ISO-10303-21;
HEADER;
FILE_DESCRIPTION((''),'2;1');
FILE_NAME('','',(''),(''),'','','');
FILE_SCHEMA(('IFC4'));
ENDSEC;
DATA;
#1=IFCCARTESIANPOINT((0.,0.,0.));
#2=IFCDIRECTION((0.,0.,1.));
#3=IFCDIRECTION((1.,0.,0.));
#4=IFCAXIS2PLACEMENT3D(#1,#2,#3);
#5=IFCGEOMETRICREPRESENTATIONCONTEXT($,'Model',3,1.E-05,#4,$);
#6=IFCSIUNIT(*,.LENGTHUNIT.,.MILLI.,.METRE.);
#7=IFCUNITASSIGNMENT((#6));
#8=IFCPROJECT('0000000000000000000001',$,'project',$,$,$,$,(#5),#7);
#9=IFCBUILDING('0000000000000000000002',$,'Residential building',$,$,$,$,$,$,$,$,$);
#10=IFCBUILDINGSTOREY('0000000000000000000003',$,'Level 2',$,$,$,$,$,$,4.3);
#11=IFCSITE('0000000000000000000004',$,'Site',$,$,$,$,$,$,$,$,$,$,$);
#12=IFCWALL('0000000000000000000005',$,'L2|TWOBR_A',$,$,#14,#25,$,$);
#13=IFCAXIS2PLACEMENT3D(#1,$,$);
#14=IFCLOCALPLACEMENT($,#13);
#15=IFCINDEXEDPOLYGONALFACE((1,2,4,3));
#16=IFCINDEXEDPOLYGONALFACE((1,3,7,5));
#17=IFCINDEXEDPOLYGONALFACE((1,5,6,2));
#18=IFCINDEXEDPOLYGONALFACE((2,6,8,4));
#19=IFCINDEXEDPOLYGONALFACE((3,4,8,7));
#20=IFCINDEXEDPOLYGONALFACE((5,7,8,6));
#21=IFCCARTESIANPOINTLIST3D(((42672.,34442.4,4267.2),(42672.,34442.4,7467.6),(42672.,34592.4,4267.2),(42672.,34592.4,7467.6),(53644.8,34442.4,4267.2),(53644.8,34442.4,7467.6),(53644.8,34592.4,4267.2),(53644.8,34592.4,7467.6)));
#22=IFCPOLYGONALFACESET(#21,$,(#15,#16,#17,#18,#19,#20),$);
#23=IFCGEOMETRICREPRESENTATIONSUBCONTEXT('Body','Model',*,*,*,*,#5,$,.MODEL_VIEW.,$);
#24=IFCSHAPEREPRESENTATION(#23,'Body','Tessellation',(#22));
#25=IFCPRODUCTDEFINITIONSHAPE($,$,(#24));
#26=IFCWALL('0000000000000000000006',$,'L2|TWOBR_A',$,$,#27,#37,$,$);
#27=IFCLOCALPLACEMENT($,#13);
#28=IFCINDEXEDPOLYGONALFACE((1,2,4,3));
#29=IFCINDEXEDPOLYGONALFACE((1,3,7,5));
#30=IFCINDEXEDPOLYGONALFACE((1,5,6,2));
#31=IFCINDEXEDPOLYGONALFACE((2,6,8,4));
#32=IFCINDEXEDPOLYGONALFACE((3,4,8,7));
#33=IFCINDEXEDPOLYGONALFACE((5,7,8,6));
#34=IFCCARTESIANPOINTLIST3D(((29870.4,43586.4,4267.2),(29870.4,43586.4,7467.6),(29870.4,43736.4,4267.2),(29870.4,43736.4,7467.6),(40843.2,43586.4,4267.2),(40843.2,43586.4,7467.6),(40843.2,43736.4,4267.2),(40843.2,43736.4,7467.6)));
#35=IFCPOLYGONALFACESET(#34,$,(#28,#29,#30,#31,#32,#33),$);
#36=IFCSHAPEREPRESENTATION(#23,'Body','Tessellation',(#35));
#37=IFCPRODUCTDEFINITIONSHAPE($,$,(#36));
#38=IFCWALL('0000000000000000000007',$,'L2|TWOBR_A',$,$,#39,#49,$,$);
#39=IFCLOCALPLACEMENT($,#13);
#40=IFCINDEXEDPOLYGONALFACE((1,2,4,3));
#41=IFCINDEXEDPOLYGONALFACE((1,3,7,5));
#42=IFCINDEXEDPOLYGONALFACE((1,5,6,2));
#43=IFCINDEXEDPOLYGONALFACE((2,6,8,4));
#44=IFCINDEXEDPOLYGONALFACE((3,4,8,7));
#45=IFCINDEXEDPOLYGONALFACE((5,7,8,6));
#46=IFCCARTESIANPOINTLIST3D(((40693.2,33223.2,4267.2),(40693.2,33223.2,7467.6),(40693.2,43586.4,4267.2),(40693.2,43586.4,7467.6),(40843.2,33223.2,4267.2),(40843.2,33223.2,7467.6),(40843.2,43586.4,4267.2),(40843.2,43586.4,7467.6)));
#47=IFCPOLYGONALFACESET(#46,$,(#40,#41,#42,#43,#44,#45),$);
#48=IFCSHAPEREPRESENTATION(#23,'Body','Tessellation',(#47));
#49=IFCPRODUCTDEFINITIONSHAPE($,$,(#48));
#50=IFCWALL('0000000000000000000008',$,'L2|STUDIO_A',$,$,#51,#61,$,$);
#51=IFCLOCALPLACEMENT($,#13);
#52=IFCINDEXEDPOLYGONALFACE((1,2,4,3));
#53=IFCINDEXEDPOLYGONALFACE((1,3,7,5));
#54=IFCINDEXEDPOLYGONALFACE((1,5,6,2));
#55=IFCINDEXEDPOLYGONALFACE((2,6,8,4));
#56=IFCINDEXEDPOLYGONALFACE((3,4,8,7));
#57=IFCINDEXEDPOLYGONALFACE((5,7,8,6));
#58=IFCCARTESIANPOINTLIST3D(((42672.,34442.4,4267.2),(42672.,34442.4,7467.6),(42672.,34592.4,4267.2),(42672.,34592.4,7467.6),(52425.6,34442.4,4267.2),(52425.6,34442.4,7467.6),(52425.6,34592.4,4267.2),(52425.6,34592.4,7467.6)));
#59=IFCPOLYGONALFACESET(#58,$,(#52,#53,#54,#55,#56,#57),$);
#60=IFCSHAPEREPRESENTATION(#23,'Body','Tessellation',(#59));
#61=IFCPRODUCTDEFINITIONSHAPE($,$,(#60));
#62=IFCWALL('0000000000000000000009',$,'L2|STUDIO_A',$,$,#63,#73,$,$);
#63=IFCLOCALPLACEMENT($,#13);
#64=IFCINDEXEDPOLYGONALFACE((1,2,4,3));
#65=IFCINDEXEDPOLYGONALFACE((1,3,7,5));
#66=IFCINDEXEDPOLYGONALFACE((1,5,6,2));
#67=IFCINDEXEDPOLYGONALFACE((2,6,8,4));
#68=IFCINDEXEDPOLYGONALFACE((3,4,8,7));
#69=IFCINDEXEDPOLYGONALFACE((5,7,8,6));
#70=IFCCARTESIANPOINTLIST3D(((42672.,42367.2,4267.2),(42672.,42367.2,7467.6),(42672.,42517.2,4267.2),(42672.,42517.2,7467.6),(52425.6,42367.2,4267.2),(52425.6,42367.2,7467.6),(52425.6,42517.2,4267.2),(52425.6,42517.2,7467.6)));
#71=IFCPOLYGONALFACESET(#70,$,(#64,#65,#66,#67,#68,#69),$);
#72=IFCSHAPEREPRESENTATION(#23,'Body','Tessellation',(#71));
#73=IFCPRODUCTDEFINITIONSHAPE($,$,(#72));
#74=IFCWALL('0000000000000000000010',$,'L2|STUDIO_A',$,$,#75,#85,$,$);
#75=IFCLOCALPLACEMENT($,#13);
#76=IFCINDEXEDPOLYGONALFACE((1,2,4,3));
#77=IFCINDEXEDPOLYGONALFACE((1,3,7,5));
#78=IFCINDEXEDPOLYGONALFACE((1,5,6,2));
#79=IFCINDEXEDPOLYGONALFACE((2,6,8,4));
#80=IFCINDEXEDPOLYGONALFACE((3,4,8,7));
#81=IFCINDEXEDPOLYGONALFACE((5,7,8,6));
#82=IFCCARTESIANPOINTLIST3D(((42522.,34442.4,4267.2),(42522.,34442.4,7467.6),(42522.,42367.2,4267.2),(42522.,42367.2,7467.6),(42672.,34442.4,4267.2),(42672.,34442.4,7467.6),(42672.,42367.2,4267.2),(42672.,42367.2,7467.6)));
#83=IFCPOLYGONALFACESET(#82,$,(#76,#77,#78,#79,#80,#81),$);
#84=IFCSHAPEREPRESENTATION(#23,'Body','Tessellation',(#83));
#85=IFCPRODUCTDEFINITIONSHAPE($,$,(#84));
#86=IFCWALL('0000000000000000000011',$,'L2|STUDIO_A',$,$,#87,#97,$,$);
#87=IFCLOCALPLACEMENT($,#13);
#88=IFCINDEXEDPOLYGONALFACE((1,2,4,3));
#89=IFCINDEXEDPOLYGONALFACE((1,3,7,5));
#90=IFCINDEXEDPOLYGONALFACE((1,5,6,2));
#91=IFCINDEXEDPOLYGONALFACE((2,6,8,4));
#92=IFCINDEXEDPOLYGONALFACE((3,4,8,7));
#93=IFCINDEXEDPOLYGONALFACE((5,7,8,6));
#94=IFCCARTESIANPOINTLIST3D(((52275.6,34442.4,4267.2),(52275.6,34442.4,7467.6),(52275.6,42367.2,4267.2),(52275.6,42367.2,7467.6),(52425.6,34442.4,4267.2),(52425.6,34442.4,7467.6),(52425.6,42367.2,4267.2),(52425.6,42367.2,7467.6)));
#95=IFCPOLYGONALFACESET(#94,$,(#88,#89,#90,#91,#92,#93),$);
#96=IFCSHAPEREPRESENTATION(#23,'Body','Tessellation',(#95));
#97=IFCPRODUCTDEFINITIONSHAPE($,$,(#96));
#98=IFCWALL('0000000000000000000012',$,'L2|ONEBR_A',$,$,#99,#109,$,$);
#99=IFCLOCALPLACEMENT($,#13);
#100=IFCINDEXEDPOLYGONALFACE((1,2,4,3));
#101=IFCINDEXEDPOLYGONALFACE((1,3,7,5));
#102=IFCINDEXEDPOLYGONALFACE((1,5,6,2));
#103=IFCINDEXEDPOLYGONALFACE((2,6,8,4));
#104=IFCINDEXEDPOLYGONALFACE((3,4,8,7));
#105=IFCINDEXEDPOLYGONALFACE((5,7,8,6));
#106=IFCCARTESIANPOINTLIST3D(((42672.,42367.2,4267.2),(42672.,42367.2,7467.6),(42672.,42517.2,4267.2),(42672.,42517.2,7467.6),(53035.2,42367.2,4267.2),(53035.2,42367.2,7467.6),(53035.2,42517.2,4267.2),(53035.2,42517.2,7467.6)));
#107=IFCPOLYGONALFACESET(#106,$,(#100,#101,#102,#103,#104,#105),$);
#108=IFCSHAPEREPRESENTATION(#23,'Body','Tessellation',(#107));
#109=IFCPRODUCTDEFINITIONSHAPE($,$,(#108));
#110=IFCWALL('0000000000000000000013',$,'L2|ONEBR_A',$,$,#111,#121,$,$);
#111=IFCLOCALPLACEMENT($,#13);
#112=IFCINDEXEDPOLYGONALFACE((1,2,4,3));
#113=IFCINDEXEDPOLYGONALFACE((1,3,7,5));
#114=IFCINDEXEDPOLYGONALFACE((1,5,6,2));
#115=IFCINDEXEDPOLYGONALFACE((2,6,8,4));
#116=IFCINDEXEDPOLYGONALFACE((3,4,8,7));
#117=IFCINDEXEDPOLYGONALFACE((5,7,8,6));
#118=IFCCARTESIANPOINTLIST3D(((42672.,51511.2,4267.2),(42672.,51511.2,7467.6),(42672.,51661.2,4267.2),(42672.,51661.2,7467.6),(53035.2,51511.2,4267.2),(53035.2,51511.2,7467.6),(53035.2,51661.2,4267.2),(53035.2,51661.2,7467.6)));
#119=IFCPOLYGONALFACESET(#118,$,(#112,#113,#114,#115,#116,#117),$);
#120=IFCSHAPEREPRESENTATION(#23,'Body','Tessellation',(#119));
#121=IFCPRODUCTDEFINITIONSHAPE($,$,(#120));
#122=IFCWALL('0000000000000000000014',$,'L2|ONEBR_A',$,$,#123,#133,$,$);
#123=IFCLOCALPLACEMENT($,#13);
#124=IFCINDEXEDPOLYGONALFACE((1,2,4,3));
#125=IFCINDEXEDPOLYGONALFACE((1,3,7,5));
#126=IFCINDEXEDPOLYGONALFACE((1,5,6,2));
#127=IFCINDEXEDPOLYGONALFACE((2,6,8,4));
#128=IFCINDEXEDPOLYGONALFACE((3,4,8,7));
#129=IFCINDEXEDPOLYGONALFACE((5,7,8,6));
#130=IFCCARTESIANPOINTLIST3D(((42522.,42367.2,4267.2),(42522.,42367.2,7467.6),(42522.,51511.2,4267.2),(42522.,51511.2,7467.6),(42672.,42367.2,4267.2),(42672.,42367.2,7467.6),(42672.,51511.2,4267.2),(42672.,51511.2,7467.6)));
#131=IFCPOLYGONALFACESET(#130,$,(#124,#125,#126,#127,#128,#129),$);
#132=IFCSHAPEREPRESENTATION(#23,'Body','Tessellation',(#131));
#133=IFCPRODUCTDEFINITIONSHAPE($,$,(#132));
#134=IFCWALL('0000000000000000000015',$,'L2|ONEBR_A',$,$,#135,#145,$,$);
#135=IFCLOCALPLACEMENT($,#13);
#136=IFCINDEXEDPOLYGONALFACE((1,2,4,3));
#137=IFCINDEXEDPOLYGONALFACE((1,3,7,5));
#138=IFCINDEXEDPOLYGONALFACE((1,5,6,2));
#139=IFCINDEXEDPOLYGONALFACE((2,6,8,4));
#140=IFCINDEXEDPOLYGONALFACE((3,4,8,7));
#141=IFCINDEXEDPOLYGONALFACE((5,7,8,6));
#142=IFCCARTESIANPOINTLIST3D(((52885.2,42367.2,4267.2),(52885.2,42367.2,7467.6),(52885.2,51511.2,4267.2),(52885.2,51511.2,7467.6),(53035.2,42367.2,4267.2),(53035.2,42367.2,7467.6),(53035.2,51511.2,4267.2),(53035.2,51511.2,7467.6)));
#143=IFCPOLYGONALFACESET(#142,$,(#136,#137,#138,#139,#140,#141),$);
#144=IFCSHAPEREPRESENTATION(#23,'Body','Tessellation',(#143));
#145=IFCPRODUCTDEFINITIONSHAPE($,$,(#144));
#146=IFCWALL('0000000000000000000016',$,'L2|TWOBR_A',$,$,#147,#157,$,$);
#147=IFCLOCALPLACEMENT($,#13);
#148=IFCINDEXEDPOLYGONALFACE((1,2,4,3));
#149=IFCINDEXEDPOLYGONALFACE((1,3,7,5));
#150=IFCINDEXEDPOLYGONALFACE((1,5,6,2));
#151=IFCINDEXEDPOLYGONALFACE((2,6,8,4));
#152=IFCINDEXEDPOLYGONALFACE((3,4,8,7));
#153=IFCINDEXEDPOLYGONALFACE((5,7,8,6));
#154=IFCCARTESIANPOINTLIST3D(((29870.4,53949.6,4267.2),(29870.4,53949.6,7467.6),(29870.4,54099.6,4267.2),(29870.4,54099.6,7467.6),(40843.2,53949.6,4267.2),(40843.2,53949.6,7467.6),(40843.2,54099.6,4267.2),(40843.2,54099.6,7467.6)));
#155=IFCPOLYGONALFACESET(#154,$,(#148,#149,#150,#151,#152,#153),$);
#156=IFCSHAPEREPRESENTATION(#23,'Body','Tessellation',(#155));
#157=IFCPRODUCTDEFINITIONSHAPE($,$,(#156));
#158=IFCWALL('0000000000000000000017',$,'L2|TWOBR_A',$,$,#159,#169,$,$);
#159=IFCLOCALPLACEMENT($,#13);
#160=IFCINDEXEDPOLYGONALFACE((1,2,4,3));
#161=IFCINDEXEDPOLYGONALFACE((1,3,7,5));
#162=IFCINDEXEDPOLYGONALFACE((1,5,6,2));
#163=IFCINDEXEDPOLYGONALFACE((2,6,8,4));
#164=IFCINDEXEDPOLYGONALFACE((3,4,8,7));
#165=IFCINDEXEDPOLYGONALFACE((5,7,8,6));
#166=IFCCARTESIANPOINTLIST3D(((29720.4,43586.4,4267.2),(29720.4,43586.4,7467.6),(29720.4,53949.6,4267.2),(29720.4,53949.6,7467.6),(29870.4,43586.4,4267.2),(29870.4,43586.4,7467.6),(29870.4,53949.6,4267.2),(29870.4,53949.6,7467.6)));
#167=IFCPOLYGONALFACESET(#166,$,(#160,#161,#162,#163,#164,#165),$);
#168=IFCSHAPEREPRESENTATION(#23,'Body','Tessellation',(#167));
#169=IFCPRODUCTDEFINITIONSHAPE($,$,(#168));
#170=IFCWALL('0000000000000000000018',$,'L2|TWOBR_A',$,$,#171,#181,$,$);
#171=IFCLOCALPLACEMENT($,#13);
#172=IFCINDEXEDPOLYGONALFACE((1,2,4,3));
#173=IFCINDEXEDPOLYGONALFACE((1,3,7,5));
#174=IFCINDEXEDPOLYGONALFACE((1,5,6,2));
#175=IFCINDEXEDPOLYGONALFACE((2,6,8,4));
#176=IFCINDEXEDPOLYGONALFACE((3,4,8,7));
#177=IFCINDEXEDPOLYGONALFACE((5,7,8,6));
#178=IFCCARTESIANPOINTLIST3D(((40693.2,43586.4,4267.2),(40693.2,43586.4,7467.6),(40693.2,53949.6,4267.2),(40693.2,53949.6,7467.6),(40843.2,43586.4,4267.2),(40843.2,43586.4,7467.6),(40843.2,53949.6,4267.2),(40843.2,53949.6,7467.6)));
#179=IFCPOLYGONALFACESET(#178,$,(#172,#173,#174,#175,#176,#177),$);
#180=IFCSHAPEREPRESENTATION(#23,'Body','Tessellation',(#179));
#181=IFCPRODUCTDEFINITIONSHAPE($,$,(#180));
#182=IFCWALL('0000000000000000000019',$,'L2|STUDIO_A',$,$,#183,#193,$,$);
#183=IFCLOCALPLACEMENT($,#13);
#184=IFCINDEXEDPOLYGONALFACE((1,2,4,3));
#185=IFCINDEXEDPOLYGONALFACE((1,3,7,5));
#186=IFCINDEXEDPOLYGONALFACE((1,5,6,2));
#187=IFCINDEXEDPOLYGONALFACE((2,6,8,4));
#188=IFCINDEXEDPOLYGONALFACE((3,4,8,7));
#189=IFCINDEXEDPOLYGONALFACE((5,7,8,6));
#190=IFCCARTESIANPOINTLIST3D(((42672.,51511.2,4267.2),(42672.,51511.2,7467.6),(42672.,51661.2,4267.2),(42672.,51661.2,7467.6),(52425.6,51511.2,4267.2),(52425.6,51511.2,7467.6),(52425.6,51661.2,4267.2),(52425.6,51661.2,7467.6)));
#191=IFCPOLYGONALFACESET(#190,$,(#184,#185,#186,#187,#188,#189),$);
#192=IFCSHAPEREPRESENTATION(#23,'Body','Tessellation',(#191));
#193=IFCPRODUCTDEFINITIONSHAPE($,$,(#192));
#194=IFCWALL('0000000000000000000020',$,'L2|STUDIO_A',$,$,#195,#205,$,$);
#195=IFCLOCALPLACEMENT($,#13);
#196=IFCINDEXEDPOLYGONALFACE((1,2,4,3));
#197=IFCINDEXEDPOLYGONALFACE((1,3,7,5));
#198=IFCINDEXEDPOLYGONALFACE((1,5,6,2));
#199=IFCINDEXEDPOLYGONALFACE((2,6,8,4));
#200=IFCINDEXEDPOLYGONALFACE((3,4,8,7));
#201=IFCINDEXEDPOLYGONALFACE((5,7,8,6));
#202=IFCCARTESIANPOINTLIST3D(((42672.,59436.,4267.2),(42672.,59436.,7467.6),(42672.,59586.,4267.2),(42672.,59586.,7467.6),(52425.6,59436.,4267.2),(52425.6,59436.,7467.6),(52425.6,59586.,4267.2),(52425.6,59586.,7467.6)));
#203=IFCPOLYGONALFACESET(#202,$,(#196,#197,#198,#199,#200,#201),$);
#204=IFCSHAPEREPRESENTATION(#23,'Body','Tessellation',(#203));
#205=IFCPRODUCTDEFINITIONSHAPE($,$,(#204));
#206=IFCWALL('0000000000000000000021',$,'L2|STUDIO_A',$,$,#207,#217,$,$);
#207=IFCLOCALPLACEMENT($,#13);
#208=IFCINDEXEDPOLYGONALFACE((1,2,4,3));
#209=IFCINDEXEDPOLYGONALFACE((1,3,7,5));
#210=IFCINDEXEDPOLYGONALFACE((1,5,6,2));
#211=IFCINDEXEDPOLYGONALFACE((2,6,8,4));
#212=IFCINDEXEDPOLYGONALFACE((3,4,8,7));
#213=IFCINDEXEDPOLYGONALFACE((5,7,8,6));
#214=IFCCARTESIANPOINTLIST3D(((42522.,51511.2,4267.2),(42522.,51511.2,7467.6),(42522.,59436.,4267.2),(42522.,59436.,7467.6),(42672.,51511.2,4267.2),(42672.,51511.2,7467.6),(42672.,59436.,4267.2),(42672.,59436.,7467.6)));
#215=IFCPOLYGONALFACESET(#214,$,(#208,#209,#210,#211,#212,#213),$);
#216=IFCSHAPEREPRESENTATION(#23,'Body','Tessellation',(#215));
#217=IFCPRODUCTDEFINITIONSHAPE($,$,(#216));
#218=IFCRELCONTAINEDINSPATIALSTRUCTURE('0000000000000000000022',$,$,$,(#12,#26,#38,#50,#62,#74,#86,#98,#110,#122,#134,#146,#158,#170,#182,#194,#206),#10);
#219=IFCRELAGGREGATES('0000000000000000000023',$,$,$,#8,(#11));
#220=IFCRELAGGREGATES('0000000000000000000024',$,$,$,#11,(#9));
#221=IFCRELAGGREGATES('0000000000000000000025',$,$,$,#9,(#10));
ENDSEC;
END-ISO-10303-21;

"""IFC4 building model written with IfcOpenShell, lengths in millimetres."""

from ifc_helpers import new_model, si_unit, frame, origin_with_axes, place, context, subcontext, project, spatial, indexed_curve, outline, extrude, element, save


model = new_model("IFC4")

# Units and contexts
model_context = context("Model", 3, precision=1e-05, world=origin_with_axes())
body_context = subcontext(model_context, "Body", "Model", "MODEL_VIEW")
ifc_project = project(units=[si_unit("LENGTHUNIT", "METRE", prefix="MILLI")], contexts=[model_context])

# Site, building, storey
site = spatial("IfcSite", under=ifc_project, Name="Site")
building = spatial("IfcBuilding", under=site, Name="Residential building")
storey = spatial("IfcBuildingStorey", under=building, Name="Level 2", Elevation=4.3)

# Walls
for number, where, z_axis, x_axis, name in (
    (1, (42672.0, 34442.4, 4267.2), (0.0, 0.0, 1.0), (1.0, 0.0, 0.0), "L2|TWOBR_A"),
    (2, (29870.4, 43586.4, 4267.2), (0.0, 0.0, 1.0), (1.0, 0.0, 0.0), "L2|TWOBR_A"),
):
    element("IfcWall", number, at=place(None, frame(where, z_axis=z_axis, x_axis=x_axis)), inside=storey, Name=name, context=body_context, shape_type="SweptSolid", body=[
        extrude(outline(indexed_curve([(0.0, 0.0), (0.0, 150.0), (10972.8, 150.0), (10972.8, 0.0), (0.0, 0.0)], self_intersect=False)), origin_with_axes(), (0.0, 0.0, 1.0), 3200.4),
    ])
wall_placement = place(None, frame((40843.2, 33223.2, 4267.2), z_axis=(0.0, 0.0, 1.0), x_axis=(0.0, 1.0, 0.0)))
element("IfcWall", 3, at=wall_placement, inside=storey, Name="L2|TWOBR_A", context=body_context, shape_type="SweptSolid", body=[
    extrude(outline(indexed_curve([(0.0, 0.0), (0.0, 150.0), (10363.2, 150.0), (10363.2, 0.0), (0.0, 0.0)], self_intersect=False)), origin_with_axes(), (0.0, 0.0, 1.0), 3200.4),
])
for number, where, z_axis, x_axis, name in (
    (4, (42672.0, 34442.4, 4267.2), (0.0, 0.0, 1.0), (1.0, 0.0, 0.0), "L2|STUDIO_A"),
    (5, (42672.0, 42367.2, 4267.2), (0.0, 0.0, 1.0), (1.0, 0.0, 0.0), "L2|STUDIO_A"),
):
    element("IfcWall", number, at=place(None, frame(where, z_axis=z_axis, x_axis=x_axis)), inside=storey, Name=name, context=body_context, shape_type="SweptSolid", body=[
        extrude(outline(indexed_curve([(0.0, 0.0), (0.0, 150.0), (9753.6, 150.0), (9753.6, 0.0), (0.0, 0.0)], self_intersect=False)), origin_with_axes(), (0.0, 0.0, 1.0), 3200.4),
    ])
for number, where, z_axis, x_axis, name in (
    (6, (42672.0, 34442.4, 4267.2), (0.0, 0.0, 1.0), (0.0, 1.0, 0.0), "L2|STUDIO_A"),
    (7, (52425.6, 34442.4, 4267.2), (0.0, 0.0, 1.0), (0.0, 1.0, 0.0), "L2|STUDIO_A"),
):
    element("IfcWall", number, at=place(None, frame(where, z_axis=z_axis, x_axis=x_axis)), inside=storey, Name=name, context=body_context, shape_type="SweptSolid", body=[
        extrude(outline(indexed_curve([(0.0, 0.0), (0.0, 150.0), (7924.8, 150.0), (7924.8, 0.0), (0.0, 0.0)], self_intersect=False)), origin_with_axes(), (0.0, 0.0, 1.0), 3200.4),
    ])
for number, where, z_axis, x_axis, name in (
    (8, (42672.0, 42367.2, 4267.2), (0.0, 0.0, 1.0), (1.0, 0.0, 0.0), "L2|ONEBR_A"),
    (9, (42672.0, 51511.2, 4267.2), (0.0, 0.0, 1.0), (1.0, 0.0, 0.0), "L2|ONEBR_A"),
):
    element("IfcWall", number, at=place(None, frame(where, z_axis=z_axis, x_axis=x_axis)), inside=storey, Name=name, context=body_context, shape_type="SweptSolid", body=[
        extrude(outline(indexed_curve([(0.0, 0.0), (0.0, 150.0), (10363.2, 150.0), (10363.2, 0.0), (0.0, 0.0)], self_intersect=False)), origin_with_axes(), (0.0, 0.0, 1.0), 3200.4),
    ])
for number, where, z_axis, x_axis, name in (
    (10, (42672.0, 42367.2, 4267.2), (0.0, 0.0, 1.0), (0.0, 1.0, 0.0), "L2|ONEBR_A"),
    (11, (53035.2, 42367.2, 4267.2), (0.0, 0.0, 1.0), (0.0, 1.0, 0.0), "L2|ONEBR_A"),
):
    element("IfcWall", number, at=place(None, frame(where, z_axis=z_axis, x_axis=x_axis)), inside=storey, Name=name, context=body_context, shape_type="SweptSolid", body=[
        extrude(outline(indexed_curve([(0.0, 0.0), (0.0, 150.0), (9144.0, 150.0), (9144.0, 0.0), (0.0, 0.0)], self_intersect=False)), origin_with_axes(), (0.0, 0.0, 1.0), 3200.4),
    ])
for number, where, z_axis, x_axis, name in (
    (12, (29870.4, 53949.6, 4267.2), (0.0, 0.0, 1.0), (1.0, 0.0, 0.0), "L2|TWOBR_A"),
):
    element("IfcWall", number, at=place(None, frame(where, z_axis=z_axis, x_axis=x_axis)), inside=storey, Name=name, context=body_context, shape_type="SweptSolid", body=[
        extrude(outline(indexed_curve([(0.0, 0.0), (0.0, 150.0), (10972.8, 150.0), (10972.8, 0.0), (0.0, 0.0)], self_intersect=False)), origin_with_axes(), (0.0, 0.0, 1.0), 3200.4),
    ])
for number, where, z_axis, x_axis, name in (
    (13, (29870.4, 43586.4, 4267.2), (0.0, 0.0, 1.0), (0.0, 1.0, 0.0), "L2|TWOBR_A"),
    (14, (40843.2, 43586.4, 4267.2), (0.0, 0.0, 1.0), (0.0, 1.0, 0.0), "L2|TWOBR_A"),
):
    element("IfcWall", number, at=place(None, frame(where, z_axis=z_axis, x_axis=x_axis)), inside=storey, Name=name, context=body_context, shape_type="SweptSolid", body=[
        extrude(outline(indexed_curve([(0.0, 0.0), (0.0, 150.0), (10363.2, 150.0), (10363.2, 0.0), (0.0, 0.0)], self_intersect=False)), origin_with_axes(), (0.0, 0.0, 1.0), 3200.4),
    ])
for number, where, z_axis, x_axis, name in (
    (15, (42672.0, 51511.2, 4267.2), (0.0, 0.0, 1.0), (1.0, 0.0, 0.0), "L2|STUDIO_A"),
    (16, (42672.0, 59436.0, 4267.2), (0.0, 0.0, 1.0), (1.0, 0.0, 0.0), "L2|STUDIO_A"),
):
    element("IfcWall", number, at=place(None, frame(where, z_axis=z_axis, x_axis=x_axis)), inside=storey, Name=name, context=body_context, shape_type="SweptSolid", body=[
        extrude(outline(indexed_curve([(0.0, 0.0), (0.0, 150.0), (9753.6, 150.0), (9753.6, 0.0), (0.0, 0.0)], self_intersect=False)), origin_with_axes(), (0.0, 0.0, 1.0), 3200.4),
    ])
for number, where, z_axis, x_axis, name in (
    (17, (42672.0, 51511.2, 4267.2), (0.0, 0.0, 1.0), (0.0, 1.0, 0.0), "L2|STUDIO_A"),
):
    element("IfcWall", number, at=place(None, frame(where, z_axis=z_axis, x_axis=x_axis)), inside=storey, Name=name, context=body_context, shape_type="SweptSolid", body=[
        extrude(outline(indexed_curve([(0.0, 0.0), (0.0, 150.0), (7924.8, 150.0), (7924.8, 0.0), (0.0, 0.0)], self_intersect=False)), origin_with_axes(), (0.0, 0.0, 1.0), 3200.4),
    ])

save(model, "model.ifc")
